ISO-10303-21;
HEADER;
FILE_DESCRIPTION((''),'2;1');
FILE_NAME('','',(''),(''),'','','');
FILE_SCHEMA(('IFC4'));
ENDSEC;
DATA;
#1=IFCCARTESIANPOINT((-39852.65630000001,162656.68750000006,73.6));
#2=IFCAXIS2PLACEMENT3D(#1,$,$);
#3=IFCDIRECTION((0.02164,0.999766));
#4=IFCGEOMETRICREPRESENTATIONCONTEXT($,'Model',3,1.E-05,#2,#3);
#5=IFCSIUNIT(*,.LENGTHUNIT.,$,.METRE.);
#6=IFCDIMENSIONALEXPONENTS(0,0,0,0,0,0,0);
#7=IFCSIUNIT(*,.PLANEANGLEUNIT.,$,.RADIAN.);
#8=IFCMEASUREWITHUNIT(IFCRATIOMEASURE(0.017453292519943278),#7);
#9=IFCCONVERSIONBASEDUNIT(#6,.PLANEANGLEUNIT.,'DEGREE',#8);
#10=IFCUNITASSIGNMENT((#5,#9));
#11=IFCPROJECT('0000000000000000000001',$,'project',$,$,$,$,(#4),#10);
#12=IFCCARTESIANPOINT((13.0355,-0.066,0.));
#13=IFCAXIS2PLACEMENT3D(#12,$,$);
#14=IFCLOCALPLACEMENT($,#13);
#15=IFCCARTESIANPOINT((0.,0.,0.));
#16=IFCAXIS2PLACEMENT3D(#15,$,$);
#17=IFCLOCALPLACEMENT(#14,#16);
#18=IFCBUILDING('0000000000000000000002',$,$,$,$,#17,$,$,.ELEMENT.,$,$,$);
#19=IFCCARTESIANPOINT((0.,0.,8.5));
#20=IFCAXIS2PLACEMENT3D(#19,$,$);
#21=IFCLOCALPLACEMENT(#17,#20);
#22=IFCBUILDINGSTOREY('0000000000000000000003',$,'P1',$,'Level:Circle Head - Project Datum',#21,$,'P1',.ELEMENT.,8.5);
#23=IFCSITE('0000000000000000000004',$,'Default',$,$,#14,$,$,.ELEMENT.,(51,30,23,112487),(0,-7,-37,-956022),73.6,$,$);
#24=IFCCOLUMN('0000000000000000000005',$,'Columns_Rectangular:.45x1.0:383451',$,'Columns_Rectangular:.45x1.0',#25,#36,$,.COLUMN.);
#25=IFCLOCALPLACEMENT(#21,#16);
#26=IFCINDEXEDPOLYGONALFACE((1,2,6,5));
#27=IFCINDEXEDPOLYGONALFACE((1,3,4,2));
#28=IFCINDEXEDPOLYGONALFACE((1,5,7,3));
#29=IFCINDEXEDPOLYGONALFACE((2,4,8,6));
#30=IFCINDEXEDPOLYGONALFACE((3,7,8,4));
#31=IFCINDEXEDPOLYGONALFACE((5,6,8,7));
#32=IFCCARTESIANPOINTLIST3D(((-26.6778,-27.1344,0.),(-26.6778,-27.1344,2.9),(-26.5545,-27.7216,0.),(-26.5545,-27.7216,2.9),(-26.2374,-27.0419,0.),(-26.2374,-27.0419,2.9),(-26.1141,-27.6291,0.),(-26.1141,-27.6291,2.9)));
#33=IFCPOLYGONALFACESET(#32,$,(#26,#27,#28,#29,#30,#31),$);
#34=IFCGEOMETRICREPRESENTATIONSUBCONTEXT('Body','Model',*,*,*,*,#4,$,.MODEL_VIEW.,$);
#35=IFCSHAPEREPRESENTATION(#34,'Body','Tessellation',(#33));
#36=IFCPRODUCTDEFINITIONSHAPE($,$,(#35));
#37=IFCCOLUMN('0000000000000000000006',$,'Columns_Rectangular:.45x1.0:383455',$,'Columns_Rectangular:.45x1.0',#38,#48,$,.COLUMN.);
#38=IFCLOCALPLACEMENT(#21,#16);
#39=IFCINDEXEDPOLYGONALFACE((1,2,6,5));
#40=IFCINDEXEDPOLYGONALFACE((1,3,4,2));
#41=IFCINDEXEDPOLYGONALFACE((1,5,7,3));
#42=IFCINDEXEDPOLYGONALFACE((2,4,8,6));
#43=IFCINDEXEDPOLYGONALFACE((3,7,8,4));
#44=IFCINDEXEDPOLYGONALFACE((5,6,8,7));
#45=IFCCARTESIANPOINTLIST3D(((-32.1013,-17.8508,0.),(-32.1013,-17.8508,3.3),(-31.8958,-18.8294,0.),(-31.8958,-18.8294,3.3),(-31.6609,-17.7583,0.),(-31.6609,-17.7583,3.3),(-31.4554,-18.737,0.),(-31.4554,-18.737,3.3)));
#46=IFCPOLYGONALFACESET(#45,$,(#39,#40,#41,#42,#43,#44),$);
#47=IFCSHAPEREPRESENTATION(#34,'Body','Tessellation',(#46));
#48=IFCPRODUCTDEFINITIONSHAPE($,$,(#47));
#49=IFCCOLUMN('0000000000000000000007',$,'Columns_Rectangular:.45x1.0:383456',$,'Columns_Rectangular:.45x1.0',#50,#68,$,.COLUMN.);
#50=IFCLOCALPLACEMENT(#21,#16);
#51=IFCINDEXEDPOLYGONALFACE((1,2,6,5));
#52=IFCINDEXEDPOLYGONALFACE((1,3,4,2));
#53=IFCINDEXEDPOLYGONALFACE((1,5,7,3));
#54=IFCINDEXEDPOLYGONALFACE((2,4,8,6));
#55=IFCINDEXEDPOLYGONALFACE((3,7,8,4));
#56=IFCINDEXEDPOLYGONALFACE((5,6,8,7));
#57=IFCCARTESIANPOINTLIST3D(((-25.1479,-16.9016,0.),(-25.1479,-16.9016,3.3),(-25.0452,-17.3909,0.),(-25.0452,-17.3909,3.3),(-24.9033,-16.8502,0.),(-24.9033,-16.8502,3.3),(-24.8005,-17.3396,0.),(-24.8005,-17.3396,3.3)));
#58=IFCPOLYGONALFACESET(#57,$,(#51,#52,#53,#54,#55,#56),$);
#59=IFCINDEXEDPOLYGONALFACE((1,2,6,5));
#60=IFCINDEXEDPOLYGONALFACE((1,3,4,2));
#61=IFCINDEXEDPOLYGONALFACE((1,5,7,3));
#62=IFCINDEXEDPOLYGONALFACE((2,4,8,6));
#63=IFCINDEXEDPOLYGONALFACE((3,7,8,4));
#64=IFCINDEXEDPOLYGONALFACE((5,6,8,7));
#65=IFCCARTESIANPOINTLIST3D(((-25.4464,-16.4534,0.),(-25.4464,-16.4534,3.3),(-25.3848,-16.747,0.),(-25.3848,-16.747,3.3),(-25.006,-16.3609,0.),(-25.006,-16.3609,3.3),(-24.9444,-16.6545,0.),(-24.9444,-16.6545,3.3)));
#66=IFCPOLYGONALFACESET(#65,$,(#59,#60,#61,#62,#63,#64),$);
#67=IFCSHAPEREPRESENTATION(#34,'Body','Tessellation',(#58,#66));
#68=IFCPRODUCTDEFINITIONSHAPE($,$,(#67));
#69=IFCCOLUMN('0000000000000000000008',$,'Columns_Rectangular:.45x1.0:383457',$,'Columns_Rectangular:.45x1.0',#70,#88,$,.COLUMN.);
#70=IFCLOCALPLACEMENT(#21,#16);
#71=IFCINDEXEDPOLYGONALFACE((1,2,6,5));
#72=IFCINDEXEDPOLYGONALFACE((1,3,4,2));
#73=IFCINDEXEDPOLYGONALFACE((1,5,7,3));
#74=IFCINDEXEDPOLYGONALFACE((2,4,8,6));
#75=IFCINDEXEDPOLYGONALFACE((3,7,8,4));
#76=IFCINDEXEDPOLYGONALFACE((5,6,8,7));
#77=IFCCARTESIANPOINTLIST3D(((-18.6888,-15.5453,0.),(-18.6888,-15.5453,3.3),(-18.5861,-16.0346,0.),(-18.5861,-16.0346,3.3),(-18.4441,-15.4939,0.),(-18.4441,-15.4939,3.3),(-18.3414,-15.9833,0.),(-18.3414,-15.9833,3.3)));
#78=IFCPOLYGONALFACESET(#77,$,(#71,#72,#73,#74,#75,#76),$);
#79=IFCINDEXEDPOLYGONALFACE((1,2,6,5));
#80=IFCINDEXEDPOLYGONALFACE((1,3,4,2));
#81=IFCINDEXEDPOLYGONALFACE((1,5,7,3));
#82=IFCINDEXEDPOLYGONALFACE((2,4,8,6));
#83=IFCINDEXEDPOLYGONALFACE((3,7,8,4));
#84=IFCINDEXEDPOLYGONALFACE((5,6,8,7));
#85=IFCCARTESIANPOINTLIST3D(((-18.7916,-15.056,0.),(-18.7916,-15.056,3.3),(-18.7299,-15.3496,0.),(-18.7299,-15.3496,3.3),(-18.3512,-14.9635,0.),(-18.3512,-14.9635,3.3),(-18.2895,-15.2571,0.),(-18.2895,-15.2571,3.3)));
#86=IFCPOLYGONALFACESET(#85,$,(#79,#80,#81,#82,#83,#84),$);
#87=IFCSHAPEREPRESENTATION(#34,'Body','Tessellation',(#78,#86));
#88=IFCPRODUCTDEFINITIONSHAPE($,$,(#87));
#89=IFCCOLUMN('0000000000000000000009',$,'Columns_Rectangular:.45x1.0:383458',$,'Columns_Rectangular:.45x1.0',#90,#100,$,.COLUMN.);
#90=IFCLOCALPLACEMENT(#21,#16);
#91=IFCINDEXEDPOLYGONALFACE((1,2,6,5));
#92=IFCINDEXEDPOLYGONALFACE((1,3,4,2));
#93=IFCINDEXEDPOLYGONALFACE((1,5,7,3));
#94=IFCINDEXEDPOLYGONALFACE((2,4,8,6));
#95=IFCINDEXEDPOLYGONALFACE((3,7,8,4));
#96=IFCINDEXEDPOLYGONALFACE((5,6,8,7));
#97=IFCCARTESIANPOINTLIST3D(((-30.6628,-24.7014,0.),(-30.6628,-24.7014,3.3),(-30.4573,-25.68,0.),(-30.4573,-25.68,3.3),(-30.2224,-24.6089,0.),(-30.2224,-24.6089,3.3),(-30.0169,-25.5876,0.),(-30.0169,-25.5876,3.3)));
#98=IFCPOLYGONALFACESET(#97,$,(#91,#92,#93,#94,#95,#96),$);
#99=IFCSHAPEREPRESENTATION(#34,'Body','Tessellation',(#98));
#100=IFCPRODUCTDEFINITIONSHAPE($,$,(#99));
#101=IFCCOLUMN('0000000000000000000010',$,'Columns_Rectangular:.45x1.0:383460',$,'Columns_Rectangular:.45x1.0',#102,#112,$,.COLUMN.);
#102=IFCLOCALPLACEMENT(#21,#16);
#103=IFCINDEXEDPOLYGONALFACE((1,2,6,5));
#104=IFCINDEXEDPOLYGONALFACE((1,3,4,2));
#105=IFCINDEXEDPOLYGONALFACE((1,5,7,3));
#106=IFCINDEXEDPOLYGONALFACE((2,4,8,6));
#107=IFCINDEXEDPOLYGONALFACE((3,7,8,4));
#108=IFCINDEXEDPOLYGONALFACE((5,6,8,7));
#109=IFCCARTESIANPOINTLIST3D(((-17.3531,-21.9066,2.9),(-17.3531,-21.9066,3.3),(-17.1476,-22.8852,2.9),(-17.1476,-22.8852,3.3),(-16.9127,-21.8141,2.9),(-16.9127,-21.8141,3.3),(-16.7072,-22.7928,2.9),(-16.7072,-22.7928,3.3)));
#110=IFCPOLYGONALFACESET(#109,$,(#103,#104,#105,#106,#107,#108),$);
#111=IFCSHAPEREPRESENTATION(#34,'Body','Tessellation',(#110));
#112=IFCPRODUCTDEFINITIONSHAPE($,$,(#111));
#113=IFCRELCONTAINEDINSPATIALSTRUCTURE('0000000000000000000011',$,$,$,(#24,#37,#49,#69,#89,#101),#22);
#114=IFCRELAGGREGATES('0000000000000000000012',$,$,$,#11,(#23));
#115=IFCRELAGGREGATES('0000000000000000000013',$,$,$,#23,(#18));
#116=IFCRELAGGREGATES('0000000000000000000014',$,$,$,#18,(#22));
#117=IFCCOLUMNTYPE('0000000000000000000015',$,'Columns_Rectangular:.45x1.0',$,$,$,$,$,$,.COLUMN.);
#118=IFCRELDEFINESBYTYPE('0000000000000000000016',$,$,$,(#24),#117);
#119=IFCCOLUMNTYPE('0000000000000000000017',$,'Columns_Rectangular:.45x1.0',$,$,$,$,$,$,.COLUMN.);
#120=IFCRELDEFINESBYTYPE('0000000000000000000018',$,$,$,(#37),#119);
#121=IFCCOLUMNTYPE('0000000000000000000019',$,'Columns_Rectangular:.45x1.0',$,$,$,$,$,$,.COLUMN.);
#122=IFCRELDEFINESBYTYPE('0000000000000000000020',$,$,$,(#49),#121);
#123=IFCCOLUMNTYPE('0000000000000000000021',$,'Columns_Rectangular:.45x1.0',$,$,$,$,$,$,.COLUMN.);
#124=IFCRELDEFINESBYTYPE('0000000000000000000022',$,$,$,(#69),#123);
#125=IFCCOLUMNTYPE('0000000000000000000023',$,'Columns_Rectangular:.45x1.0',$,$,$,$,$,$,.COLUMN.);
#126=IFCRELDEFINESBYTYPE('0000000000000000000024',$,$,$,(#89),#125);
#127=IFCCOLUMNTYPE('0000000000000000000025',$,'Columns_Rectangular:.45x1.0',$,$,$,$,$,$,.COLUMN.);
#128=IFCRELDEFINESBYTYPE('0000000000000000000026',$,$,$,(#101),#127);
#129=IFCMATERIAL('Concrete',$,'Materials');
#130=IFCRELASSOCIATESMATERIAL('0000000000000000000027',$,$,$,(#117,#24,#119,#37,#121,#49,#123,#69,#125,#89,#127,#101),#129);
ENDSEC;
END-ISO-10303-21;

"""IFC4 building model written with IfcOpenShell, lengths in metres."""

from ifc_helpers import new_model, entity, si_unit, converted_unit, direction, frame, origin, place, context, subcontext, project, spatial, indexed_curve, outline, extrude, source, transform, mapped, material, type_object, type_shapes, element, save


model = new_model("IFC4")

# Units and contexts
model_context = context("Model", 3, precision=1e-05, world=frame((-39852.65630000001, 162656.68750000006, 73.6)), true_north=direction((0.02164, 0.999766)))
body_context = subcontext(model_context, "Body", "Model", "MODEL_VIEW")
ifc_project = project(units=[si_unit("LENGTHUNIT", "METRE"), converted_unit("PLANEANGLEUNIT", "DEGREE", entity("IfcRatioMeasure", 0.017453292519943278), si_unit("PLANEANGLEUNIT", "RADIAN"), dimensions=[0, 0, 0, 0, 0, 0, 0])], contexts=[model_context])

# Site, building, storey
site_placement = place(None, frame((13.0355, -0.066, 0.0)))
site = spatial("IfcSite", under=ifc_project, at=site_placement, Name="Default", CompositionType="ELEMENT", RefLatitude=(51, 30, 23, 112487), RefLongitude=(0, -7, -37, -956022), RefElevation=73.6)
building_placement = place(site_placement, origin())
building = spatial("IfcBuilding", under=site, at=building_placement, CompositionType="ELEMENT")
storey_placement = place(building_placement, frame((0.0, 0.0, 8.5)))
storey = spatial("IfcBuildingStorey", under=building, at=storey_placement, Name="P1", ObjectType="Level:Circle Head - Project Datum", LongName="P1", CompositionType="ELEMENT", Elevation=8.5)

# Columns
ifc_material = material(Name="Concrete", Category="Materials")
column_type_1 = type_object("IfcColumnType", Name="Columns_Rectangular:.45x1.0", PredefinedType="COLUMN", material=ifc_material)
shared_shape_1 = source(origin(), body_context, "Body", "SweptSolid", [
    extrude(outline(indexed_curve([(-0.3, -0.225), (0.3, -0.225), (0.3, 0.225), (-0.3, 0.225), (-0.3, -0.225)], self_intersect=False)), frame((-26.3959, -27.3817, 8.5), z_axis=(0.0, 0.0, 1.0), x_axis=(-0.2055, 0.978657, 0.0)), (0.0, 0.0, 1.0), 2.9),
])
type_shapes(column_type_1, [shared_shape_1])
column_1_placement = place(storey_placement, frame((0.0, 0.0, -8.5)))
element("IfcColumn", 1, at=column_1_placement, inside=storey, type_object=column_type_1, material=ifc_material, Name="Columns_Rectangular:.45x1.0:383451", ObjectType="Columns_Rectangular:.45x1.0", PredefinedType="COLUMN", context=body_context, shape_type="MappedRepresentation", body=[
    mapped(shared_shape_1, transform((0.0, 0.0, 0.0), scale=1.0)),
])
column_type_2 = type_object("IfcColumnType", Name="Columns_Rectangular:.45x1.0", PredefinedType="COLUMN", material=ifc_material)
shared_shape_2 = source(origin(), body_context, "Body", "SweptSolid", [
    extrude(outline(indexed_curve([(-0.5, -0.225), (0.5, -0.225), (0.5, 0.225), (-0.5, 0.225), (-0.5, -0.225)], self_intersect=False)), frame((-31.7784, -18.2939, 8.5), z_axis=(0.0, 0.0, 1.0), x_axis=(-0.2055, 0.978657, 0.0)), (0.0, 0.0, 1.0), 3.3),
])
type_shapes(column_type_2, [shared_shape_2])
column_2_placement = place(storey_placement, frame((0.0, 0.0, -8.5)))
element("IfcColumn", 2, at=column_2_placement, inside=storey, type_object=column_type_2, material=ifc_material, Name="Columns_Rectangular:.45x1.0:383455", ObjectType="Columns_Rectangular:.45x1.0", PredefinedType="COLUMN", context=body_context, shape_type="MappedRepresentation", body=[
    mapped(shared_shape_2, transform((0.0, 0.0, 0.0), scale=1.0)),
])
column_type_3 = type_object("IfcColumnType", Name="Columns_Rectangular:.45x1.0", PredefinedType="COLUMN", material=ifc_material)
shared_shape_3 = source(origin(), body_context, "Body", "SweptSolid", [
    extrude(outline(indexed_curve([(-0.25, -0.125), (0.25, -0.125), (0.25, 0.125), (-0.25, 0.125), (-0.25, -0.125)], self_intersect=False)), frame((-24.9742, -17.1206, 8.5), z_axis=(0.0, 0.0, 1.0), x_axis=(-0.2055, 0.978657, 0.0)), (0.0, 0.0, 1.0), 3.3),
    extrude(outline(indexed_curve([(-0.225, -0.15), (0.225, -0.15), (0.225, 0.15), (-0.225, 0.15), (-0.225, -0.15)], self_intersect=False)), frame((-25.1954, -16.5539, 8.5), z_axis=(0.0, 0.0, 1.0), x_axis=(-0.978657, -0.2055, 0.0)), (0.0, 0.0, 1.0), 3.3),
])
type_shapes(column_type_3, [shared_shape_3])
column_3_placement = place(storey_placement, frame((0.0, 0.0, -8.5)))
element("IfcColumn", 3, at=column_3_placement, inside=storey, type_object=column_type_3, material=ifc_material, Name="Columns_Rectangular:.45x1.0:383456", ObjectType="Columns_Rectangular:.45x1.0", PredefinedType="COLUMN", context=body_context, shape_type="MappedRepresentation", body=[
    mapped(shared_shape_3, transform((0.0, 0.0, 0.0), scale=1.0)),
])
column_type_4 = type_object("IfcColumnType", Name="Columns_Rectangular:.45x1.0", PredefinedType="COLUMN", material=ifc_material)
shared_shape_4 = source(origin(), body_context, "Body", "SweptSolid", [
    extrude(outline(indexed_curve([(-0.25, -0.125), (0.25, -0.125), (0.25, 0.125), (-0.25, 0.125), (-0.25, -0.125)], self_intersect=False)), frame((-18.5151, -15.7643, 8.5), z_axis=(0.0, 0.0, 1.0), x_axis=(-0.2055, 0.978657, 0.0)), (0.0, 0.0, 1.0), 3.3),
    extrude(outline(indexed_curve([(-0.225, -0.15), (0.225, -0.15), (0.225, 0.15), (-0.225, 0.15), (-0.225, -0.15)], self_intersect=False)), frame((-18.5405, -15.1565, 8.5), z_axis=(0.0, 0.0, 1.0), x_axis=(-0.978657, -0.2055, 0.0)), (0.0, 0.0, 1.0), 3.3),
])
type_shapes(column_type_4, [shared_shape_4])
column_4_placement = place(storey_placement, frame((0.0, 0.0, -8.5)))
element("IfcColumn", 4, at=column_4_placement, inside=storey, type_object=column_type_4, material=ifc_material, Name="Columns_Rectangular:.45x1.0:383457", ObjectType="Columns_Rectangular:.45x1.0", PredefinedType="COLUMN", context=body_context, shape_type="MappedRepresentation", body=[
    mapped(shared_shape_4, transform((0.0, 0.0, 0.0), scale=1.0)),
])
column_type_5 = type_object("IfcColumnType", Name="Columns_Rectangular:.45x1.0", PredefinedType="COLUMN", material=ifc_material)
shared_shape_5 = source(origin(), body_context, "Body", "SweptSolid", [
    extrude(outline(indexed_curve([(-0.5, -0.225), (0.5, -0.225), (0.5, 0.225), (-0.5, 0.225), (-0.5, -0.225)], self_intersect=False)), frame((-30.3399, -25.1445, 8.5), z_axis=(0.0, 0.0, 1.0), x_axis=(-0.2055, 0.978657, 0.0)), (0.0, 0.0, 1.0), 3.3),
])
type_shapes(column_type_5, [shared_shape_5])
column_5_placement = place(storey_placement, frame((0.0, 0.0, -8.5)))
element("IfcColumn", 5, at=column_5_placement, inside=storey, type_object=column_type_5, material=ifc_material, Name="Columns_Rectangular:.45x1.0:383458", ObjectType="Columns_Rectangular:.45x1.0", PredefinedType="COLUMN", context=body_context, shape_type="MappedRepresentation", body=[
    mapped(shared_shape_5, transform((0.0, 0.0, 0.0), scale=1.0)),
])
column_type_6 = type_object("IfcColumnType", Name="Columns_Rectangular:.45x1.0", PredefinedType="COLUMN", material=ifc_material)
shared_shape_6 = source(origin(), body_context, "Body", "SweptSolid", [
    extrude(outline(indexed_curve([(-0.225, -0.5), (0.225, -0.5), (0.225, 0.5), (-0.225, 0.5), (-0.225, -0.5)], self_intersect=False)), frame((-17.0301, -22.3497, 11.4), z_axis=(0.0, 0.0, 1.0), x_axis=(-0.978657, -0.2055, 0.0)), (0.0, 0.0, 1.0), 0.4),
])
type_shapes(column_type_6, [shared_shape_6])
column_6_placement = place(storey_placement, frame((0.0, 0.0, -8.5)))
element("IfcColumn", 6, at=column_6_placement, inside=storey, type_object=column_type_6, material=ifc_material, Name="Columns_Rectangular:.45x1.0:383460", ObjectType="Columns_Rectangular:.45x1.0", PredefinedType="COLUMN", context=body_context, shape_type="MappedRepresentation", body=[
    mapped(shared_shape_6, transform((0.0, 0.0, 0.0), scale=1.0)),
])

save(model, "model.ifc")
